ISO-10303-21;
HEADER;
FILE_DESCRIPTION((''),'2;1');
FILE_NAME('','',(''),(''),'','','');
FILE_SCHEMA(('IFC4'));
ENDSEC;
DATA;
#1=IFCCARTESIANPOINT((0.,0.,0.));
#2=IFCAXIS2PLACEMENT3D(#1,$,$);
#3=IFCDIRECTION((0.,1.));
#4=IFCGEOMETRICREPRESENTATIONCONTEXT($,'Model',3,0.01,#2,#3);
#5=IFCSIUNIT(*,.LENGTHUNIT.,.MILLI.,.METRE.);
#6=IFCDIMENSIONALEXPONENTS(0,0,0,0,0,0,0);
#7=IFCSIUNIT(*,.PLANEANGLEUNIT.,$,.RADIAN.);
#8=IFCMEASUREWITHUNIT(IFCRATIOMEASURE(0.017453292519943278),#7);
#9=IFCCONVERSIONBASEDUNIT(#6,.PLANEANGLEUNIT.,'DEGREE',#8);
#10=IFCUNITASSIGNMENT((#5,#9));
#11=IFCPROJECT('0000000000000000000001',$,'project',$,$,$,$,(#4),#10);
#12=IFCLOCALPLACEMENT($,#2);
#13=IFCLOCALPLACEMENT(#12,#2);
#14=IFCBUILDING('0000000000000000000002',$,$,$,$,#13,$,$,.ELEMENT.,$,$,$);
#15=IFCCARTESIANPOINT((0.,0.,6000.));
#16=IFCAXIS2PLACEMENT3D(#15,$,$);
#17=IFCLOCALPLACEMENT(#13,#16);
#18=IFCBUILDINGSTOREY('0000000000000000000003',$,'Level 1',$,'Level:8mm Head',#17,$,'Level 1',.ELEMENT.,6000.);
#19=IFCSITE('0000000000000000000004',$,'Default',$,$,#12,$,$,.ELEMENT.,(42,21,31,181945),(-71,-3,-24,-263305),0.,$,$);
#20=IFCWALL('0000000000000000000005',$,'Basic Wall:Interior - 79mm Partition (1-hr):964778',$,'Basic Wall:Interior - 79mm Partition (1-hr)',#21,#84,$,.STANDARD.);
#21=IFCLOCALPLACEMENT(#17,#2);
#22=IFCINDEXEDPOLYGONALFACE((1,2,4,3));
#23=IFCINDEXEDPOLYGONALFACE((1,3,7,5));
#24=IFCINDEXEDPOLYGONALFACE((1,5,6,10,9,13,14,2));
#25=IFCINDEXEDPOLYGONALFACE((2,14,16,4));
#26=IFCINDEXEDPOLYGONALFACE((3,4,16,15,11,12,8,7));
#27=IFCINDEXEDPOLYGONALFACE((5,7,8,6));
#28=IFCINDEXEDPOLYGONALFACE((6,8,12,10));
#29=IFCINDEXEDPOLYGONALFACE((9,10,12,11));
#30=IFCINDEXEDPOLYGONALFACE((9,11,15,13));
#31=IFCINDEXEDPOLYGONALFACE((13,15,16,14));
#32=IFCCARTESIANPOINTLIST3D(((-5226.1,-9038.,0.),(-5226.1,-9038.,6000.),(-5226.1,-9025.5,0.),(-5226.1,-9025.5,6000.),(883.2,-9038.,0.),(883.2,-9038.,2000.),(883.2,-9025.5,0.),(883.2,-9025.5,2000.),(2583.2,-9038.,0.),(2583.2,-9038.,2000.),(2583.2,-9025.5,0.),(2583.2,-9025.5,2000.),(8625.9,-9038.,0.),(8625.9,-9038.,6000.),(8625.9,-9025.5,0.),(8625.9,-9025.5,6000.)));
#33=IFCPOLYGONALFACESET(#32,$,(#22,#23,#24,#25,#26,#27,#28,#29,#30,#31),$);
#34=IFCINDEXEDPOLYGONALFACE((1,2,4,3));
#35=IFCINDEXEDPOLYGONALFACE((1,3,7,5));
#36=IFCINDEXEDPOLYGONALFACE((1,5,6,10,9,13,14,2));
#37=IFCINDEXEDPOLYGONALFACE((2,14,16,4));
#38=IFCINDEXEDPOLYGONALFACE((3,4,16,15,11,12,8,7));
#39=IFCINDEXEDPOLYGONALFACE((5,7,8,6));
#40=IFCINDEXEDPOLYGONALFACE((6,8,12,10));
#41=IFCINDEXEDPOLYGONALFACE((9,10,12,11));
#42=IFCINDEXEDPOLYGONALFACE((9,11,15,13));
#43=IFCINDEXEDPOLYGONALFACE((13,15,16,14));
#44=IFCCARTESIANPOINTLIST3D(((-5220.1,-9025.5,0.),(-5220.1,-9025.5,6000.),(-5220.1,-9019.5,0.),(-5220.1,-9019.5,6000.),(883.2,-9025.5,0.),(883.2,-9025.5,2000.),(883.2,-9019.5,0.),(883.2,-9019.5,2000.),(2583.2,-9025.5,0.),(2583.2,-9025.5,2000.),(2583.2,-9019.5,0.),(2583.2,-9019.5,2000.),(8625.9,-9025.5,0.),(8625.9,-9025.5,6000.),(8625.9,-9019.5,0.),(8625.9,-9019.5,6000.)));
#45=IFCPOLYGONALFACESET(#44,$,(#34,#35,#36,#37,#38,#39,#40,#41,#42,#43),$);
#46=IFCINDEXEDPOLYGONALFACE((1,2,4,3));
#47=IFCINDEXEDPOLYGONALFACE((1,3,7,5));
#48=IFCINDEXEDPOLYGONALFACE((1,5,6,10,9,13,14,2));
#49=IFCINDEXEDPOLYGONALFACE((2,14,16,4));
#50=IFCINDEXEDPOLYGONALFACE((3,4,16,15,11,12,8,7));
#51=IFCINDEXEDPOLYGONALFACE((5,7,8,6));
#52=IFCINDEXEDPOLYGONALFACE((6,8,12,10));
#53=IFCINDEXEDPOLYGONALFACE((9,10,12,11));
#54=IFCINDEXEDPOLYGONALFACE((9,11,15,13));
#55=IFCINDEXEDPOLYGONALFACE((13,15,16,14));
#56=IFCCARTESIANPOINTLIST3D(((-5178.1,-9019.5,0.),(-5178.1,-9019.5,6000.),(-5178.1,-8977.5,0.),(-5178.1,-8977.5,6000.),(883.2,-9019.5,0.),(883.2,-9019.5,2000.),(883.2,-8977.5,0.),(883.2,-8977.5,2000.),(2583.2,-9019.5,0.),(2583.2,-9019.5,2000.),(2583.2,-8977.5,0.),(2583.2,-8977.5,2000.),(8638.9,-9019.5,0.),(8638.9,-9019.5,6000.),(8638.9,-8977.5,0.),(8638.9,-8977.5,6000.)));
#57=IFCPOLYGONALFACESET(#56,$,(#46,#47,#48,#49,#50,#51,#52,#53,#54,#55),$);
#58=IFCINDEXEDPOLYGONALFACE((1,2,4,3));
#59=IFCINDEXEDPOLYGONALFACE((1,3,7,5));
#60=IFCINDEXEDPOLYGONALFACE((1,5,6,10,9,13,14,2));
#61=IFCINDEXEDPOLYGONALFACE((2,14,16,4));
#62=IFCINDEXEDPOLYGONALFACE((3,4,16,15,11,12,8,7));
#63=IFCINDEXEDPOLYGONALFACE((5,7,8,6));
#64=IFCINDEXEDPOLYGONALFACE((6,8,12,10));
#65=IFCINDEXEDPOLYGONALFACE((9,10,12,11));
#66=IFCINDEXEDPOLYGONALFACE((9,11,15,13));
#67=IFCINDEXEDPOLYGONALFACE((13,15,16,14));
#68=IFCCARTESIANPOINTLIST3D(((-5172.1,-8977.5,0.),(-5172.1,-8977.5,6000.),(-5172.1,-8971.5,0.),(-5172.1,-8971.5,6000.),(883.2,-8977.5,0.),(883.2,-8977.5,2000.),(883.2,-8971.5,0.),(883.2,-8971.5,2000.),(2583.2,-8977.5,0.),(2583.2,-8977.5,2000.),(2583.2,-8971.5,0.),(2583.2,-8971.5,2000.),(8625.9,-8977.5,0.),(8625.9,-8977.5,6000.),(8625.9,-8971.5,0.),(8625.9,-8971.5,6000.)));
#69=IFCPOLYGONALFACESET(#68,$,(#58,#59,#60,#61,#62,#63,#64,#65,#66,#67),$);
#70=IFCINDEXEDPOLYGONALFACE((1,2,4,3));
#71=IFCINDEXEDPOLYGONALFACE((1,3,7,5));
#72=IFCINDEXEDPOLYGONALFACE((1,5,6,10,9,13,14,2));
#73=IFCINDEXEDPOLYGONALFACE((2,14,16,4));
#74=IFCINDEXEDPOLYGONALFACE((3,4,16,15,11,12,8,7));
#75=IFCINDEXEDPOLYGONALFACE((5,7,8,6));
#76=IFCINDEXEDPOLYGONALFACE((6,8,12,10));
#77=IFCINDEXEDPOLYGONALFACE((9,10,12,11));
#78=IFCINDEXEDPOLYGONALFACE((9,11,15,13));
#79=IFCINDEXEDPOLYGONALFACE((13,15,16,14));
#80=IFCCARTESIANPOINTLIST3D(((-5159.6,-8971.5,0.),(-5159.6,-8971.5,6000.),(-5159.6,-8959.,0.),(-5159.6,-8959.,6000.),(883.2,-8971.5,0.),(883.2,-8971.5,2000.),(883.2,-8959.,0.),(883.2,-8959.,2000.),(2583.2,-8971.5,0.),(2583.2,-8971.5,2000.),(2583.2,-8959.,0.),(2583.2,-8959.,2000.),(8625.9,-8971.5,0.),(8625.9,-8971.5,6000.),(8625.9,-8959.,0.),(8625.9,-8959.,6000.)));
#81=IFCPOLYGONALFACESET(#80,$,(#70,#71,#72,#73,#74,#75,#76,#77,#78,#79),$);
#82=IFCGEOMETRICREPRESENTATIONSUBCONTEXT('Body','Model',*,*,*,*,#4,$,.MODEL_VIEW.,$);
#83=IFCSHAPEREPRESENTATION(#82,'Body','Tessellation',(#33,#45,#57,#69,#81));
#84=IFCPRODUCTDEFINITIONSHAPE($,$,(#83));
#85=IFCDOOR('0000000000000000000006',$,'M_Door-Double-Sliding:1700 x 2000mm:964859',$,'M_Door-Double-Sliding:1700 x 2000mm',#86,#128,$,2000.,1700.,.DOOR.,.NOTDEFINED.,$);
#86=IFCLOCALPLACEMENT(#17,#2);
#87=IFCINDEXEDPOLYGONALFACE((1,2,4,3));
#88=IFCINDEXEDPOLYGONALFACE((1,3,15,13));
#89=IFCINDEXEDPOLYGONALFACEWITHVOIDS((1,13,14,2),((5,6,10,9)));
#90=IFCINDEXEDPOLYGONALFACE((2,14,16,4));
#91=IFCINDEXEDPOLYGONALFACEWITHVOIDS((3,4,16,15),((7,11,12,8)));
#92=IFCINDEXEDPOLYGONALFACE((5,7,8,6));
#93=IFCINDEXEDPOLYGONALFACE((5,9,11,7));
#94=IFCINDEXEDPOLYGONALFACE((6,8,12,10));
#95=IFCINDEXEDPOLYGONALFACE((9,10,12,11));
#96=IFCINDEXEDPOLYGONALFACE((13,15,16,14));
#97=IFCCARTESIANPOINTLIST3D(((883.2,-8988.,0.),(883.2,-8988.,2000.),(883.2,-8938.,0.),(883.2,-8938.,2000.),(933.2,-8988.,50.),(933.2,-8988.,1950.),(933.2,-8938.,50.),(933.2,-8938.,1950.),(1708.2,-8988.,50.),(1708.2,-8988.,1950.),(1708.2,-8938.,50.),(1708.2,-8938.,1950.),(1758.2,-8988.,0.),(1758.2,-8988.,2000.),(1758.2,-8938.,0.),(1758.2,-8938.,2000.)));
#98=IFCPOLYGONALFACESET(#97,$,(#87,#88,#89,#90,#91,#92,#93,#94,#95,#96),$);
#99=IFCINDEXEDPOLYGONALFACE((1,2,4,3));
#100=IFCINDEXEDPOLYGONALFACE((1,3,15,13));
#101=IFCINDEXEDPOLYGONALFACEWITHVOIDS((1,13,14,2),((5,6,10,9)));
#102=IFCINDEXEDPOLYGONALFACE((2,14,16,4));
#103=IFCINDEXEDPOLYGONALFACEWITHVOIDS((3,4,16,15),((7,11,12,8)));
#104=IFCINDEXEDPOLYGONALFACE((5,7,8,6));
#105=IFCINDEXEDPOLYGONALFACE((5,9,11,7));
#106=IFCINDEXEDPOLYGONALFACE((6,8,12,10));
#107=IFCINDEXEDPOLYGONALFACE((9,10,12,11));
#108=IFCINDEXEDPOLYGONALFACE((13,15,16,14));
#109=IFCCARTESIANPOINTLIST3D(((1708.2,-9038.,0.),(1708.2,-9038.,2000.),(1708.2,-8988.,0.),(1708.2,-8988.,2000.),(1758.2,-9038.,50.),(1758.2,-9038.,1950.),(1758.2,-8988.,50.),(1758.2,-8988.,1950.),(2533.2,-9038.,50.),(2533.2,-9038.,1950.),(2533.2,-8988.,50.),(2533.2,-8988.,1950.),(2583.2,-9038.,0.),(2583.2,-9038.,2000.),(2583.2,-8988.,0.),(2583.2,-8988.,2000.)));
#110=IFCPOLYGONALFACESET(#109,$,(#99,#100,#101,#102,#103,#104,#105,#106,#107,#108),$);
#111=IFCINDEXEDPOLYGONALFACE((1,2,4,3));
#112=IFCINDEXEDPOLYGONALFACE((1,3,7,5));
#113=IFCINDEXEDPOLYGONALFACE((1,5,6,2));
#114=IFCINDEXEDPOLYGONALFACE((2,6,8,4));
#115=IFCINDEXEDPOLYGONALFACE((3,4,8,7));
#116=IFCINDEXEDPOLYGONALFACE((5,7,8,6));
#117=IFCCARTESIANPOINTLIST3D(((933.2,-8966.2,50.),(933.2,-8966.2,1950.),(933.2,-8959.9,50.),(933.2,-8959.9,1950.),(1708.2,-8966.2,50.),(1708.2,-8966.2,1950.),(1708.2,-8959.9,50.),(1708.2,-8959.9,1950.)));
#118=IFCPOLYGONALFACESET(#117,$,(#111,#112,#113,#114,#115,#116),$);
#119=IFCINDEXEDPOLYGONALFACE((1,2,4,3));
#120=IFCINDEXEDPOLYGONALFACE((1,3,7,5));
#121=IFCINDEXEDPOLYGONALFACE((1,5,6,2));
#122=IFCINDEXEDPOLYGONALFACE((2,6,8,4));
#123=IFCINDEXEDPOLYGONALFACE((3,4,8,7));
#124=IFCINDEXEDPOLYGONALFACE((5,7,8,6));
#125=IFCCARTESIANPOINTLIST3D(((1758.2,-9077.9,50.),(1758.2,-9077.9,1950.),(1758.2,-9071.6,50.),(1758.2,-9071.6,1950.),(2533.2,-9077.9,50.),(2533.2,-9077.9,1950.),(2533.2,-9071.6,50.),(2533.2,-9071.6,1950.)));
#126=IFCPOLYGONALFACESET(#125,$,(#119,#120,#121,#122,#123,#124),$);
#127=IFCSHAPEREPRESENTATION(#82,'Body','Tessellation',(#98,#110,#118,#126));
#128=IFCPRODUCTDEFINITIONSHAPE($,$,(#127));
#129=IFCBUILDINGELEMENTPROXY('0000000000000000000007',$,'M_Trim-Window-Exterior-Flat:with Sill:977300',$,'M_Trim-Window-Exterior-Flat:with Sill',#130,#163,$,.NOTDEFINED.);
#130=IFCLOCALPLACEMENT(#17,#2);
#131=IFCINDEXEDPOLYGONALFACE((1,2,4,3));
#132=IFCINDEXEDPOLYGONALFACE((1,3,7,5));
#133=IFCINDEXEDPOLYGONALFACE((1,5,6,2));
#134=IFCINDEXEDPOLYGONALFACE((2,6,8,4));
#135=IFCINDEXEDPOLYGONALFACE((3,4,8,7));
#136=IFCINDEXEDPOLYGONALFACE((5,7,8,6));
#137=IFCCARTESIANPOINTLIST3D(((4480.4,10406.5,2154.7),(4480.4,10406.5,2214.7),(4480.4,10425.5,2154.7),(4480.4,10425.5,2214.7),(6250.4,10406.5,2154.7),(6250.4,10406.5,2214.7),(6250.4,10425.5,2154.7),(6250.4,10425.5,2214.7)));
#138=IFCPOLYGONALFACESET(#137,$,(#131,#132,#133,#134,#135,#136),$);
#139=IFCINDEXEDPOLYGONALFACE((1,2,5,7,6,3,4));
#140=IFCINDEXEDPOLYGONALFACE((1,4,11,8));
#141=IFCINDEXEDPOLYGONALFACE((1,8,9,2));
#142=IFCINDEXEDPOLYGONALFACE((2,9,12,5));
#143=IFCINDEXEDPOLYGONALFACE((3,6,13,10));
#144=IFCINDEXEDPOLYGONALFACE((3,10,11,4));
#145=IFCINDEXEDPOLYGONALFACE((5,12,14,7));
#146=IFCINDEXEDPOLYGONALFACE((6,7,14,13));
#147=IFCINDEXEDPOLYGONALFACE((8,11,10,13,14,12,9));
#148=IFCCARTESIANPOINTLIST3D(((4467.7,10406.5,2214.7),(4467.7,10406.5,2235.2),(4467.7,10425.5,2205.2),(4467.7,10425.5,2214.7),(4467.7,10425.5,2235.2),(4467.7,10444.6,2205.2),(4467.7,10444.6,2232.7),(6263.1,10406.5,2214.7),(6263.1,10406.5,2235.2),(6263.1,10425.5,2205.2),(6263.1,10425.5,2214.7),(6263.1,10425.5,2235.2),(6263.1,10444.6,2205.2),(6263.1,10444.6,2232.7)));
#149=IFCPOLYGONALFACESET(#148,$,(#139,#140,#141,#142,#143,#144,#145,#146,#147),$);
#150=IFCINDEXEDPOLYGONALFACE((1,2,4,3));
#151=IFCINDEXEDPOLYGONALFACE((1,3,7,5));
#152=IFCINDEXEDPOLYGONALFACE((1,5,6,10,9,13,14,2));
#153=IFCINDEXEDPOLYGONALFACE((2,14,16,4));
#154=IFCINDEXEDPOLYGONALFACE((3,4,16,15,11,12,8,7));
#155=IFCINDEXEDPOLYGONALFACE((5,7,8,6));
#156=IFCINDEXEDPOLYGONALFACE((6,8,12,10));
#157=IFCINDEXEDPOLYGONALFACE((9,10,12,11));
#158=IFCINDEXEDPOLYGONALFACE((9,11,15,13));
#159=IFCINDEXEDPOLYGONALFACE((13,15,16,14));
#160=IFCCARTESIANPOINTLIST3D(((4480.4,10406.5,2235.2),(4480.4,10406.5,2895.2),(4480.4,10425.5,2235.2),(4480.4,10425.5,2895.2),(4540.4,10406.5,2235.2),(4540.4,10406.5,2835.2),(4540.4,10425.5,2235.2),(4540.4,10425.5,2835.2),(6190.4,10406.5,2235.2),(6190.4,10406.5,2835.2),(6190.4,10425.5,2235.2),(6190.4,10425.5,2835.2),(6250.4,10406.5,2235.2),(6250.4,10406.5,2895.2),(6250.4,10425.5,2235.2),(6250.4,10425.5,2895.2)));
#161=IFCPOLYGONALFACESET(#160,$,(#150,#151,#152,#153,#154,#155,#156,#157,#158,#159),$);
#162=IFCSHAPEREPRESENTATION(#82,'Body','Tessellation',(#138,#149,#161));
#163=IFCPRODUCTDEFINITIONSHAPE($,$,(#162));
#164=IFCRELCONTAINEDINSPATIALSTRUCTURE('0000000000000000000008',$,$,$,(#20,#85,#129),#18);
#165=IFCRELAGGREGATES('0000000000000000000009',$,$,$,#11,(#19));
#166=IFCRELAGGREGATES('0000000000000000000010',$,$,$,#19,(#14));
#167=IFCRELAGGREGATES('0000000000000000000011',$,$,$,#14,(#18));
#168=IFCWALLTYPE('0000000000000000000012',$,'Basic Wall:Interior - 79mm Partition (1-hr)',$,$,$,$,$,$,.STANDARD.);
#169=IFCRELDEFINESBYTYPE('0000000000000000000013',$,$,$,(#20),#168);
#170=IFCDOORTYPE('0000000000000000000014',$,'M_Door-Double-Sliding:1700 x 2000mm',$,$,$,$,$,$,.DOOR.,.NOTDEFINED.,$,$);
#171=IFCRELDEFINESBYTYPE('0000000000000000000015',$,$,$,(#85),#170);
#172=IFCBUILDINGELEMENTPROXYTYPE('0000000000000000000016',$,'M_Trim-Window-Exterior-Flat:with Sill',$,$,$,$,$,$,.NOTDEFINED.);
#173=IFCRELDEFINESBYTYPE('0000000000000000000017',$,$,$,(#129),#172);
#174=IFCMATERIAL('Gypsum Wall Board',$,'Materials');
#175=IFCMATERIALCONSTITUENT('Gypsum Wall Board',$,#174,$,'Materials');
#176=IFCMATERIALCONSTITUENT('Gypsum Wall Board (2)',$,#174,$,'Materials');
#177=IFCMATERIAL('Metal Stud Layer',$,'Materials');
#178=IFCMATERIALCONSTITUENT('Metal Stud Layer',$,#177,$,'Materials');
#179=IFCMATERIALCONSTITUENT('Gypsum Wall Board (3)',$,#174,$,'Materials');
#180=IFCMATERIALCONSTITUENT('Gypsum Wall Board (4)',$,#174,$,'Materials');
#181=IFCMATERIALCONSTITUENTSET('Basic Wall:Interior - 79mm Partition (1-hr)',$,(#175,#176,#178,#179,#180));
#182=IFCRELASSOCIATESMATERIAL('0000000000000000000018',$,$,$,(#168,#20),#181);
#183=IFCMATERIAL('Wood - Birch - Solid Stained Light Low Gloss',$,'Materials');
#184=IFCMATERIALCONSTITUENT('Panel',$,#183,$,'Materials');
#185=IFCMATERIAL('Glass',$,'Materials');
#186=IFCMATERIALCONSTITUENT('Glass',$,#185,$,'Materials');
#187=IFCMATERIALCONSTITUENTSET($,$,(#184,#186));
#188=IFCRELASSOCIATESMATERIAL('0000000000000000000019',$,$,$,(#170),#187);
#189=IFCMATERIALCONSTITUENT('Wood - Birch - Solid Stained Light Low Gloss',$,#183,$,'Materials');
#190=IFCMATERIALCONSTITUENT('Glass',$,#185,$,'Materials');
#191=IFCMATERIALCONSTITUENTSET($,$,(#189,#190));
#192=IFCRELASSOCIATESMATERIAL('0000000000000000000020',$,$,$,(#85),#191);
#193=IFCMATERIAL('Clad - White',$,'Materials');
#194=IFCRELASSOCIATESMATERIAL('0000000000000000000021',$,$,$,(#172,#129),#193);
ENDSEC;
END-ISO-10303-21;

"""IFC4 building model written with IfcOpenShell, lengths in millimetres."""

from ifc_helpers import new_model, entity, si_unit, converted_unit, direction, frame, origin, place, context, subcontext, project, spatial, indexed_curve, outline, extrude, source, transform, mapped, material, constituent, constituent_set, type_object, type_shapes, element, fill, save


model = new_model("IFC4")

# Units and contexts
model_context = context("Model", 3, precision=0.01, world=origin(), true_north=direction((0.0, 1.0)))
body_context = subcontext(model_context, "Body", "Model", "MODEL_VIEW")
ifc_project = project(units=[si_unit("LENGTHUNIT", "METRE", prefix="MILLI"), converted_unit("PLANEANGLEUNIT", "DEGREE", entity("IfcRatioMeasure", 0.017453292519943278), si_unit("PLANEANGLEUNIT", "RADIAN"), dimensions=[0, 0, 0, 0, 0, 0, 0])], contexts=[model_context])

# Site, building, storey
site_placement = place(None, origin())
site = spatial("IfcSite", under=ifc_project, at=site_placement, Name="Default", CompositionType="ELEMENT", RefLatitude=(42, 21, 31, 181945), RefLongitude=(-71, -3, -24, -263305), RefElevation=0.0)
building_placement = place(site_placement, origin())
building = spatial("IfcBuilding", under=site, at=building_placement, CompositionType="ELEMENT")
storey_placement = place(building_placement, frame((0.0, 0.0, 6000.0)))
storey = spatial("IfcBuildingStorey", under=building, at=storey_placement, Name="Level 1", ObjectType="Level:8mm Head", LongName="Level 1", CompositionType="ELEMENT", Elevation=6000.0)

# Shared definitions
ifc_material_1 = material(Name="Gypsum Wall Board", Category="Materials")
ifc_constituent_1 = constituent(ifc_material_1, Name="Gypsum Wall Board", Category="Materials")
ifc_constituent_2 = constituent(ifc_material_1, Name="Gypsum Wall Board (2)", Category="Materials")
ifc_material_2 = material(Name="Metal Stud Layer", Category="Materials")
ifc_constituent_3 = constituent(ifc_material_2, Name="Metal Stud Layer", Category="Materials")
ifc_constituent_4 = constituent(ifc_material_1, Name="Gypsum Wall Board (3)", Category="Materials")
ifc_constituent_5 = constituent(ifc_material_1, Name="Gypsum Wall Board (4)", Category="Materials")
ifc_constituent_set_1 = constituent_set(constituents=[ifc_constituent_1, ifc_constituent_2, ifc_constituent_3, ifc_constituent_4, ifc_constituent_5], Name="Basic Wall:Interior - 79mm Partition (1-hr)")
wall_type = type_object("IfcWallType", Name="Basic Wall:Interior - 79mm Partition (1-hr)", PredefinedType="STANDARD", material=ifc_constituent_set_1)

# Wall, opening, door
ifc_material_3 = material(Name="Wood - Birch - Solid Stained Light Low Gloss", Category="Materials")
ifc_material_4 = material(Name="Glass", Category="Materials")
ifc_constituent_6 = constituent(ifc_material_3, Name="Panel", Category="Materials")
ifc_constituent_7 = constituent(ifc_material_4, Name="Glass", Category="Materials")
ifc_constituent_set_2 = constituent_set(constituents=[ifc_constituent_6, ifc_constituent_7])
door_type = type_object("IfcDoorType", Name="M_Door-Double-Sliding:1700 x 2000mm", OperationType="NOTDEFINED", PredefinedType="DOOR", material=ifc_constituent_set_2)
shared_shape_1 = source(origin(), body_context, "Body", "SweptSolid", [
    extrude(outline(indexed_curve([(-437.5, -1000.0), (437.5, -1000.0), (437.5, 1000.0), (-437.5, 1000.0), (-437.5, -1000.0)], self_intersect=False), holes=[indexed_curve([(-387.5, -950.0), (-387.5, 950.0), (387.5, 950.0), (387.5, -950.0), (-387.5, -950.0)], self_intersect=False)]), frame((1262.5, -21.0, 1000.0), z_axis=(0.0, 1.0, 0.0), x_axis=(1.0, 0.0, 0.0)), (0.0, 0.0, 1.0), 50.0),
    extrude(outline(indexed_curve([(-1000.0, -437.5), (1000.0, -437.5), (1000.0, 437.5), (-1000.0, 437.5), (-1000.0, -437.5)], self_intersect=False), holes=[indexed_curve([(-950.0, -387.5), (-950.0, 387.5), (950.0, 387.5), (950.0, -387.5), (-950.0, -387.5)], self_intersect=False)]), frame((437.5, 29.0, 1000.0), z_axis=(0.0, 1.0, 0.0), x_axis=(0.0, 0.0, -1.0)), (0.0, 0.0, 1.0), 50.0),
    extrude(outline(indexed_curve([(-3.2, -387.5), (3.2, -387.5), (3.2, 387.5), (-3.2, 387.5), (-3.2, -387.5)], self_intersect=False)), frame((1262.5, 4.0, 50.0), z_axis=(0.0, 0.0, 1.0), x_axis=(0.0, -1.0, 0.0)), (0.0, 0.0, 1.0), 1900.0),
    extrude(outline(indexed_curve([(-3.2, -387.5), (3.2, -387.5), (3.2, 387.5), (-3.2, 387.5), (-3.2, -387.5)], self_intersect=False)), frame((437.5, 115.7, 50.0), z_axis=(0.0, 0.0, 1.0), x_axis=(0.0, 1.0, 0.0)), (0.0, 0.0, 1.0), 1900.0),
])
type_shapes(door_type, [shared_shape_1])
wall_1_placement = place(storey_placement, frame((-5159.6, -8998.5, 0.0)))
wall_1 = element("IfcWall", 1, at=wall_1_placement, inside=storey, type_object=wall_type, material=ifc_constituent_set_1, Name="Basic Wall:Interior - 79mm Partition (1-hr):964778", ObjectType="Basic Wall:Interior - 79mm Partition (1-hr)", PredefinedType="STANDARD", context=body_context, shape_type="SweptSolid", body=[
    extrude(outline(indexed_curve([(-2000.0, -6942.6), (4000.0, -6942.6), (4000.0, 6909.4), (-2000.0, 6909.4), (-2000.0, 866.6), (0.0, 866.6), (0.0, -833.4), (-2000.0, -833.4), (-2000.0, -6942.6)], self_intersect=False)), frame((6876.1, -39.5, 2000.0), z_axis=(0.0, 1.0, 0.0), x_axis=(0.0, 0.0, 1.0)), (0.0, 0.0, 1.0), 12.5),
    extrude(outline(indexed_curve([(-2000.0, -865.1), (-2000.0, -6907.9), (4000.0, -6907.9), (4000.0, 6938.1), (-2000.0, 6938.1), (-2000.0, 834.9), (0.0, 834.9), (0.0, -865.1), (-2000.0, -865.1)], self_intersect=False)), frame((6877.6, -27.0, 2000.0), z_axis=(0.0, -1.0, 0.0), x_axis=(0.0, 0.0, 1.0)), (0.0, 0.0, -1.0), 6.0),
    extrude(outline(indexed_curve([(-2000.0, -851.4), (-2000.0, -6907.1), (4000.0, -6907.1), (4000.0, 6909.9), (-2000.0, 6909.9), (-2000.0, 848.6), (0.0, 848.6), (0.0, -851.4), (-2000.0, -851.4)], self_intersect=False)), frame((6891.4, -21.0, 2000.0), z_axis=(0.0, -1.0, 0.0), x_axis=(0.0, 0.0, 1.0)), (0.0, 0.0, -1.0), 42.0),
    extrude(outline(indexed_curve([(-2000.0, -853.1), (-2000.0, -6895.9), (4000.0, -6895.9), (4000.0, 6902.1), (-2000.0, 6902.1), (-2000.0, 846.9), (0.0, 846.9), (0.0, -853.1), (-2000.0, -853.1)], self_intersect=False)), frame((6889.6, 21.0, 2000.0), z_axis=(0.0, -1.0, 0.0), x_axis=(0.0, 0.0, 1.0)), (0.0, 0.0, -1.0), 6.0),
    extrude(outline(indexed_curve([(-2000.0, -850.0), (-2000.0, -6892.8), (4000.0, -6892.8), (4000.0, 6892.8), (-2000.0, 6892.8), (-2000.0, 850.0), (0.0, 850.0), (0.0, -850.0), (-2000.0, -850.0)], self_intersect=False)), frame((6892.8, 27.0, 2000.0), z_axis=(0.0, -1.0, 0.0), x_axis=(0.0, 0.0, 1.0)), (0.0, 0.0, -1.0), 12.5),
])
opening_1_placement = place(wall_1_placement, frame((7742.8, 39.5, 0.0)))
opening_1 = element("IfcOpeningElement", 2, at=opening_1_placement, cuts=wall_1, PredefinedType="OPENING", context=body_context, shape_type="SweptSolid", body=[
    extrude(outline(indexed_curve([(2000.0, 0.0), (2000.0, 1700.0), (0.0, 1700.0), (0.0, 0.0), (2000.0, 0.0)], self_intersect=False)), frame((0.0, 0.0, 0.0), z_axis=(0.0, -1.0, 0.0), x_axis=(0.0, 0.0, 1.0)), (0.0, 0.0, 1.0), 79.0),
])
ifc_constituent_8 = constituent(ifc_material_3, Name="Wood - Birch - Solid Stained Light Low Gloss", Category="Materials")
ifc_constituent_9 = constituent(ifc_material_4, Name="Glass", Category="Materials")
ifc_constituent_set_3 = constituent_set(constituents=[ifc_constituent_8, ifc_constituent_9])
door_1_placement = place(opening_1_placement, frame((0.0, 0.0, 0.0), z_axis=(0.0, 0.0, 1.0), x_axis=(-1.0, 0.0, 0.0)))
door_1 = element("IfcDoor", 3, at=door_1_placement, inside=storey, type_object=door_type, material=ifc_constituent_set_3, Name="M_Door-Double-Sliding:1700 x 2000mm:964859", ObjectType="M_Door-Double-Sliding:1700 x 2000mm", OperationType="NOTDEFINED", OverallHeight=2000.0, OverallWidth=1700.0, PredefinedType="DOOR", context=body_context, shape_type="MappedRepresentation", body=[
    mapped(shared_shape_1, transform((0.0, 0.0, 0.0), scale=1.0)),
])
fill(opening_1, door_1)

# Building element proxy
ifc_material_5 = material(Name="Clad - White", Category="Materials")
building_element_proxy_type_1 = type_object("IfcBuildingElementProxyType", Name="M_Trim-Window-Exterior-Flat:with Sill", PredefinedType="NOTDEFINED", material=ifc_material_5)
shared_shape_2 = source(origin(), body_context, "Body", "SweptSolid", [
    extrude(outline(indexed_curve([(-885.0, -30.0), (885.0, -30.0), (885.0, 30.0), (-885.0, 30.0), (-885.0, -30.0)], self_intersect=False)), frame((0.0, -650.4, 0.0), z_axis=(0.0, 0.0, 1.0), x_axis=(-1.0, 0.0, 0.0)), (0.0, 0.0, 1.0), 19.0),
    extrude(outline(indexed_curve([(-19.0, -15.2), (0.0, -15.2), (0.0, -5.7), (19.0, -5.7), (19.0, 14.8), (0.0, 14.8), (-19.0, 12.3), (-19.0, -15.2)], self_intersect=False)), frame((-897.7, -614.8, 19.0), z_axis=(1.0, 0.0, 0.0), x_axis=(0.0, 0.0, -1.0)), (0.0, 0.0, 1.0), 1795.4),
    extrude(outline(indexed_curve([(-345.0, -885.0), (315.0, -885.0), (315.0, -825.0), (-285.0, -825.0), (-285.0, 825.0), (315.0, 825.0), (315.0, 885.0), (-345.0, 885.0), (-345.0, -885.0)], self_intersect=False)), frame((0.0, -285.0, 0.0), z_axis=(0.0, 0.0, 1.0), x_axis=(0.0, -1.0, 0.0)), (0.0, 0.0, 1.0), 19.0),
])
type_shapes(building_element_proxy_type_1, [shared_shape_2])
for number, where, z_axis, x_axis, name in (
    (4, (5365.4, 10406.5, 2835.2), (0.0, 1.0, 0.0), (-1.0, 0.0, 0.0), "M_Trim-Window-Exterior-Flat:with Sill:977300"),
):
    element("IfcBuildingElementProxy", number, at=place(storey_placement, frame(where, z_axis=z_axis, x_axis=x_axis)), inside=storey, type_object=building_element_proxy_type_1, material=ifc_material_5, Name=name, ObjectType="M_Trim-Window-Exterior-Flat:with Sill", PredefinedType="NOTDEFINED", context=body_context, shape_type="MappedRepresentation", body=[
        mapped(shared_shape_2, transform((0.0, 0.0, 0.0), scale=1.0)),
    ])

save(model, "model.ifc")
